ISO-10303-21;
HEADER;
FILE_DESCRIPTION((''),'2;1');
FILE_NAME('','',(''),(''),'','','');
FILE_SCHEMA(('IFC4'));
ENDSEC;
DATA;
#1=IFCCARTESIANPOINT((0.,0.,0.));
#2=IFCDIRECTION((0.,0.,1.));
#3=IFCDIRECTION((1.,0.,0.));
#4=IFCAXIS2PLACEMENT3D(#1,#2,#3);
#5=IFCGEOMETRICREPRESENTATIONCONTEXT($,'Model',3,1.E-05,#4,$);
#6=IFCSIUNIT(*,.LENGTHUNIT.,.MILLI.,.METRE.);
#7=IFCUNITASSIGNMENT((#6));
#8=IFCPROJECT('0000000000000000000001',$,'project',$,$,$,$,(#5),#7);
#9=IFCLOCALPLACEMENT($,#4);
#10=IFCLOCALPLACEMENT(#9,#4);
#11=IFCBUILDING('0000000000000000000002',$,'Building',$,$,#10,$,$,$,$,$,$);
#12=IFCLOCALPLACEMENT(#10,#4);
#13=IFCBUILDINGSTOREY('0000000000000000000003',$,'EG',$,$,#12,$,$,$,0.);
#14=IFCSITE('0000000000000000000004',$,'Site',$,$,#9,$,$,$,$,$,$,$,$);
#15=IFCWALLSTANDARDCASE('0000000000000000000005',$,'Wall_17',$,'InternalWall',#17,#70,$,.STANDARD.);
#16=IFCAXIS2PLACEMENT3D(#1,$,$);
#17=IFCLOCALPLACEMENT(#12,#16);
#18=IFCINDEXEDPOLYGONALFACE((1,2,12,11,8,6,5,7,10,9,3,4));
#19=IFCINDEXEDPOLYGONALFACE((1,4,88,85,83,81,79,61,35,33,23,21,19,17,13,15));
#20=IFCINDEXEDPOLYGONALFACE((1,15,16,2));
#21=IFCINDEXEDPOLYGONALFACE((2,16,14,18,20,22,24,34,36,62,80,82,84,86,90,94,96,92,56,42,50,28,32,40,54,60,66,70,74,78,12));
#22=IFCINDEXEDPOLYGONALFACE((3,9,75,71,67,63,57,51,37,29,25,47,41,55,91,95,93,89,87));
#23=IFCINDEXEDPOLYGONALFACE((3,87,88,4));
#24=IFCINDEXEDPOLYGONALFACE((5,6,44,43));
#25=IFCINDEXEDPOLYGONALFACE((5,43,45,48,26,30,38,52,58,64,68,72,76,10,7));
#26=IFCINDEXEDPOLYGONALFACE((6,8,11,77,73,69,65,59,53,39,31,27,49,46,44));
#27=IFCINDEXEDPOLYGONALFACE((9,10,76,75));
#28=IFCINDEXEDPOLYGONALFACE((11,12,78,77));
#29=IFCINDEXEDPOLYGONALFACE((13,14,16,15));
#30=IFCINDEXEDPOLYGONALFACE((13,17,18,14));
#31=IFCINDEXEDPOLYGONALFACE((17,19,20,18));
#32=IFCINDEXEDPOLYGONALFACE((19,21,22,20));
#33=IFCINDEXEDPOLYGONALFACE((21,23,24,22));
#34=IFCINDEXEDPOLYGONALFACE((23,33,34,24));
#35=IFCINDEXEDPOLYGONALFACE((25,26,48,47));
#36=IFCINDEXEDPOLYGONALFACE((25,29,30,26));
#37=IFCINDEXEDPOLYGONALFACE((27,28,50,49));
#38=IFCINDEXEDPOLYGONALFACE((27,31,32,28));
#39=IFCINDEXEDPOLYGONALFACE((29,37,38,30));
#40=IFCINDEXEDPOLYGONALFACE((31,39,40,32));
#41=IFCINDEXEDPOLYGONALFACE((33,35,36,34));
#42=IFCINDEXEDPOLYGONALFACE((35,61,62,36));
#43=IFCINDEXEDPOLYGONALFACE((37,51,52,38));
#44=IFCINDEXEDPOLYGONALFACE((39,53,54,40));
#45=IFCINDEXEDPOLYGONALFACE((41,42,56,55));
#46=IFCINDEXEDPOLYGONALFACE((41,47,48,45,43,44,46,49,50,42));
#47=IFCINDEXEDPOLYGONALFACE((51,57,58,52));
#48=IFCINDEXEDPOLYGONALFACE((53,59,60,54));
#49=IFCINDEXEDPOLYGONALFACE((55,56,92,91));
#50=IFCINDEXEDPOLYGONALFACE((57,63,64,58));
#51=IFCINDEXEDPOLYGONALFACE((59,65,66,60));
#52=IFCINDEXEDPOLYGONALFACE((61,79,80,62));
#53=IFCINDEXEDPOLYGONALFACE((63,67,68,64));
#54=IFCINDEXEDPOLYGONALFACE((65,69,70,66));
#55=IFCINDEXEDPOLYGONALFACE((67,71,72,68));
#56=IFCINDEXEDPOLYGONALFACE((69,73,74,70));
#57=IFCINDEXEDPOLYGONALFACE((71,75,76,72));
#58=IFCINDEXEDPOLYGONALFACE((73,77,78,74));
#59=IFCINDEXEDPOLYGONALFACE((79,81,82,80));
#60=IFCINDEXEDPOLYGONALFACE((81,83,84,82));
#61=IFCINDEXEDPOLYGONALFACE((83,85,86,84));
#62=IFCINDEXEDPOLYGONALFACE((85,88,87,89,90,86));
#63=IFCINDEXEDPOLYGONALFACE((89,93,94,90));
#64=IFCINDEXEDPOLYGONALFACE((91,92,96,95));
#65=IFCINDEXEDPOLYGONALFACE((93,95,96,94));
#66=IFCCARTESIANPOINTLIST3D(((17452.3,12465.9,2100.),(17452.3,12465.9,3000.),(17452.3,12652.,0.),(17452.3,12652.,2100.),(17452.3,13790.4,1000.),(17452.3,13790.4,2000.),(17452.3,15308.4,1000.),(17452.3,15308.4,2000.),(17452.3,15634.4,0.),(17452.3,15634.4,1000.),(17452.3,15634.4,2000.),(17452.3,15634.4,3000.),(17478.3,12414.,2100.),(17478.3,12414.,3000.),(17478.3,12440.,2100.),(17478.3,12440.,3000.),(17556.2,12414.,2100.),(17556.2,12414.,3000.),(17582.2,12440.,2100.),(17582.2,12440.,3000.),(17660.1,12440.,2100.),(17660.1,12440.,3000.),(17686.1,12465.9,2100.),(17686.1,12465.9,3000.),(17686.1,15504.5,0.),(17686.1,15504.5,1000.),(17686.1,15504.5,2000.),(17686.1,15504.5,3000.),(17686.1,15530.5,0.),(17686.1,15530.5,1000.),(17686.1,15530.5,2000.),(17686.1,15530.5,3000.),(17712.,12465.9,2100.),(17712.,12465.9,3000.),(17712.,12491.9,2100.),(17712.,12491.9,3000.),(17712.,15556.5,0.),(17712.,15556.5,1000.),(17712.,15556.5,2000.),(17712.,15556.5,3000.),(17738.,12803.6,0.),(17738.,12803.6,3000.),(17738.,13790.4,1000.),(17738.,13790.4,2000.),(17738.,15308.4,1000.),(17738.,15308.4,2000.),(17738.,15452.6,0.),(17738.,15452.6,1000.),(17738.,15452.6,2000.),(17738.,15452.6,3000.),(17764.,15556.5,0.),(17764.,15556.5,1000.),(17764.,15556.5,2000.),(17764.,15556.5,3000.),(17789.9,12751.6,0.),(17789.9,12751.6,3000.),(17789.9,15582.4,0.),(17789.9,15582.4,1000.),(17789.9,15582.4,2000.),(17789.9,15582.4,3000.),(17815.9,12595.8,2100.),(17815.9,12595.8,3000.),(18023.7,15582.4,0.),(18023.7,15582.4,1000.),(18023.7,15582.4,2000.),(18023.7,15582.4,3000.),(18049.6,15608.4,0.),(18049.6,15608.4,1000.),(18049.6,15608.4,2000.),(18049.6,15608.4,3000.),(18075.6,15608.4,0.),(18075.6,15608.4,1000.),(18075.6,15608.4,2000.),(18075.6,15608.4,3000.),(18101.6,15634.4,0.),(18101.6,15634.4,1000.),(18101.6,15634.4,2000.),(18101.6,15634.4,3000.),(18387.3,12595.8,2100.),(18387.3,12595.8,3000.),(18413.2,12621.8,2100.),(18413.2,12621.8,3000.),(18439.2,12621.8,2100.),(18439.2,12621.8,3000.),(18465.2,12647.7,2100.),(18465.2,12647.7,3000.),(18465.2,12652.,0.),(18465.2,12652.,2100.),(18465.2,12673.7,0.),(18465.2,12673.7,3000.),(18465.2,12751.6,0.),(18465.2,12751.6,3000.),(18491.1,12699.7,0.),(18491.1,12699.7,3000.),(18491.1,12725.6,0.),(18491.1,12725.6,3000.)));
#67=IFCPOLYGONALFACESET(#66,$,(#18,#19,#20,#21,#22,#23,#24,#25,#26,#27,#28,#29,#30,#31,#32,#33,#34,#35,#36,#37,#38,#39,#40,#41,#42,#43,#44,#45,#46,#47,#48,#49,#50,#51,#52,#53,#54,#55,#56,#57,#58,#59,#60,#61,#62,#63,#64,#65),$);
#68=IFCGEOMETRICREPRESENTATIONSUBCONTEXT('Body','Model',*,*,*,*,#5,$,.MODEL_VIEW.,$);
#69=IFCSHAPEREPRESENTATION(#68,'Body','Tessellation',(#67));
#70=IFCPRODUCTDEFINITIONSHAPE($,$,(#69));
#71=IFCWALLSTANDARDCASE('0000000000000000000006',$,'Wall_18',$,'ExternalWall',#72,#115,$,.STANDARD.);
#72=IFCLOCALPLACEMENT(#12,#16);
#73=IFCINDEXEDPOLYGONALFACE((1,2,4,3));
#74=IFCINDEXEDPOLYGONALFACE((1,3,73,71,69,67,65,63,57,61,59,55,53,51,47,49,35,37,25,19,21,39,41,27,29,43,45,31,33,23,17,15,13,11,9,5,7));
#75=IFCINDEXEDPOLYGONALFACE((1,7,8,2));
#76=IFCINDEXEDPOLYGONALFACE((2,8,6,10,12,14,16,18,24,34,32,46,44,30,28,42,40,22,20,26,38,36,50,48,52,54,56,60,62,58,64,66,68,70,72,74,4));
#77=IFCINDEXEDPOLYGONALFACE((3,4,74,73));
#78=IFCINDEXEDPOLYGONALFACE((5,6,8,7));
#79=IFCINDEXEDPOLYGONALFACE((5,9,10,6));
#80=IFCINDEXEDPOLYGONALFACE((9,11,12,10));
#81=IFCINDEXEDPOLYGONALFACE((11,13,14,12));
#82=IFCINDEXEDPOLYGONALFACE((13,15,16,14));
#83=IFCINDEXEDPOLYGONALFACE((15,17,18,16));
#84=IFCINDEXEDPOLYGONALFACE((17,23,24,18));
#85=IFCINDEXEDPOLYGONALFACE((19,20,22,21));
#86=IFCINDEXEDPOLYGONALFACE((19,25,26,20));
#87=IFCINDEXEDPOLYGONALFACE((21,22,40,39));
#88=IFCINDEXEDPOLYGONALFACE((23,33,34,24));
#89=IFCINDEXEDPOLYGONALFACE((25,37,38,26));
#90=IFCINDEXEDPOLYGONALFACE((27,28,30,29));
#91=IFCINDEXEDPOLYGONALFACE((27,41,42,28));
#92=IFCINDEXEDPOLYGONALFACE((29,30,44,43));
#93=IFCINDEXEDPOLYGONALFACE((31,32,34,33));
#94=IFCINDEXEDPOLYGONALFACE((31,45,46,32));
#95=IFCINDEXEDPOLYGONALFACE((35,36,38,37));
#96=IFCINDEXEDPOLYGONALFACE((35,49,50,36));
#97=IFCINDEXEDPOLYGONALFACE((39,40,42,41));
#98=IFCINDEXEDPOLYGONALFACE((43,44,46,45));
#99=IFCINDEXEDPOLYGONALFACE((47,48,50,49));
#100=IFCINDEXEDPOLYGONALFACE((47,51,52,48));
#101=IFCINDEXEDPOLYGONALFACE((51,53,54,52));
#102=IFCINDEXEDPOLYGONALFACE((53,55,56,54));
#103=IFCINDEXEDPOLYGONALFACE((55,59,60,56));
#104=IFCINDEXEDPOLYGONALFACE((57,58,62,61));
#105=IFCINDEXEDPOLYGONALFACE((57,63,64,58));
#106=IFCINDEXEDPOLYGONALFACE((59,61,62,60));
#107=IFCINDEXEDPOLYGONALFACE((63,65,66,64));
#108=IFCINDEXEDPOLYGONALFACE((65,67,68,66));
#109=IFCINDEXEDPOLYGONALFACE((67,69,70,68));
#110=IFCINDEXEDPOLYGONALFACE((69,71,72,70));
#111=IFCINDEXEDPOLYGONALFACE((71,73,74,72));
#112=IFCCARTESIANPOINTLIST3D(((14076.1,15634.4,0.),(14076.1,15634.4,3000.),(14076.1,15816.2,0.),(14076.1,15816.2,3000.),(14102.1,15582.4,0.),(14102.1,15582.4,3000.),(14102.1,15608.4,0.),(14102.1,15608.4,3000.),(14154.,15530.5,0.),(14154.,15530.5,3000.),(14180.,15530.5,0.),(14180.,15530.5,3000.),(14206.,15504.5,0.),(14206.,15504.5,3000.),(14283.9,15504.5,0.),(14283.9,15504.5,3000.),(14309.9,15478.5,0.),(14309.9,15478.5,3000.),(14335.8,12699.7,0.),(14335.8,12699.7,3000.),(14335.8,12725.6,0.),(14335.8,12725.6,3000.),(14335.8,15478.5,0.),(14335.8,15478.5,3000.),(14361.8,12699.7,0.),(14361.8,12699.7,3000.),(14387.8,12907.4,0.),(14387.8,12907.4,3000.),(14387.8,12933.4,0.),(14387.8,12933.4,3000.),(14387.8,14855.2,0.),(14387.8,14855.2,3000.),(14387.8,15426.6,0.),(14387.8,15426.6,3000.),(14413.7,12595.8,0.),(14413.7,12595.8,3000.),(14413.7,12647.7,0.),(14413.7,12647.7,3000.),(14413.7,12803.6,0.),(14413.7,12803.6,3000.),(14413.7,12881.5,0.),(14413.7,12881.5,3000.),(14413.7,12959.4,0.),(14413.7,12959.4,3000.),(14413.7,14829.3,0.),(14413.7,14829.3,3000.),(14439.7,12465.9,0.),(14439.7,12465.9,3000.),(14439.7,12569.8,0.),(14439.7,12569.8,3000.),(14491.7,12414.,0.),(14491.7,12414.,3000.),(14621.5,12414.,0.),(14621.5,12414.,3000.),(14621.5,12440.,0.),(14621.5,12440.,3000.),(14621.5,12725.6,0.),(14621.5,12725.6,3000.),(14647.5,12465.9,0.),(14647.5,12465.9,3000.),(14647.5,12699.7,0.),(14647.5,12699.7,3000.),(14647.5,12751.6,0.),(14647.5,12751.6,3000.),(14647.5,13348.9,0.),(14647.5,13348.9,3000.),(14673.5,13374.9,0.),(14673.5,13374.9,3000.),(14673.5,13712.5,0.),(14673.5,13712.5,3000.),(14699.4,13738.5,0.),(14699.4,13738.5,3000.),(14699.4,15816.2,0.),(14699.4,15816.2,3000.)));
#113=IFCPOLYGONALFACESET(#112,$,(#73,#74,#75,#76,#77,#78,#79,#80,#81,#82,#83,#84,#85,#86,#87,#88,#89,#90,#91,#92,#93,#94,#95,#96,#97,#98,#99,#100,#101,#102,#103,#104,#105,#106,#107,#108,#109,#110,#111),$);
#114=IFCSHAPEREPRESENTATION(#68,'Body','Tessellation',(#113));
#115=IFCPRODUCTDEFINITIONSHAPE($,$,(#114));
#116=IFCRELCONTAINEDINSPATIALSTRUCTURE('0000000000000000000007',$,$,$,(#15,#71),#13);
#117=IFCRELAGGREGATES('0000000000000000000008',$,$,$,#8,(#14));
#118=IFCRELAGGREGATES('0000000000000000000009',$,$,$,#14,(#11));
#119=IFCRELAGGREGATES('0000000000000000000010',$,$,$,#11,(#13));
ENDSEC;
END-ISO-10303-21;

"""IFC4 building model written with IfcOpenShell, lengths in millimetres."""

from ifc_helpers import new_model, si_unit, frame, origin_with_axes, place, context, subcontext, project, spatial, polyline, rectangle, outline, extrude, element, save


model = new_model("IFC4")

# Units and contexts
model_context = context("Model", 3, precision=1e-05, world=origin_with_axes())
body_context = subcontext(model_context, "Body", "Model", "MODEL_VIEW")
ifc_project = project(units=[si_unit("LENGTHUNIT", "METRE", prefix="MILLI")], contexts=[model_context])

# Site, building, storey
site_placement = place(None, origin_with_axes())
site = spatial("IfcSite", under=ifc_project, at=site_placement, Name="Site")
building_placement = place(site_placement, origin_with_axes())
building = spatial("IfcBuilding", under=site, at=building_placement, Name="Building")
storey_placement = place(building_placement, origin_with_axes())
storey = spatial("IfcBuildingStorey", under=building, at=storey_placement, Name="EG", Elevation=0.0)

# Wall, openings
wall_1_placement = place(storey_placement, origin_with_axes())
wall_1 = element("IfcWallStandardCase", 1, at=wall_1_placement, inside=storey, Name="Wall_17", ObjectType="InternalWall", PredefinedType="STANDARD", context=body_context, shape_type="SweptSolid", body=[
    extrude(outline(polyline([(17478.3, 12414.0, 0.0), (17478.3, 12440.0, 0.0), (17452.3, 12465.9, 0.0), (17452.3, 15634.4, 0.0), (18101.6, 15634.4, 0.0), (18075.6, 15608.4, 0.0), (18049.6, 15608.4, 0.0), (18023.7, 15582.4, 0.0), (17789.9, 15582.4, 0.0), (17764.0, 15556.5, 0.0), (17712.0, 15556.5, 0.0), (17686.1, 15530.5, 0.0), (17686.1, 15504.5, 0.0), (17738.0, 15452.6, 0.0), (17738.0, 12803.6, 0.0), (17789.9, 12751.6, 0.0), (18465.2, 12751.6, 0.0), (18491.1, 12725.6, 0.0), (18491.1, 12699.7, 0.0), (18465.2, 12673.7, 0.0), (18465.2, 12647.7, 0.0), (18439.2, 12621.8, 0.0), (18413.2, 12621.8, 0.0), (18387.3, 12595.8, 0.0), (17815.9, 12595.8, 0.0), (17712.0, 12491.9, 0.0), (17712.0, 12465.9, 0.0), (17686.1, 12465.9, 0.0), (17660.1, 12440.0, 0.0), (17582.2, 12440.0, 0.0), (17556.2, 12414.0, 0.0), (17478.3, 12414.0, 0.0)])), origin_with_axes(), (0.0, 0.0, 1.0), 3000.0),
])
opening_1_placement = place(wall_1_placement, origin_with_axes())
element("IfcOpeningElement", 2, at=opening_1_placement, inside=storey, cuts=wall_1, context=body_context, shape_type="SweptSolid", body=[
    extrude(rectangle(XDim=450.0, YDim=1038.8), frame((17971.7, 12427.0, 0.0), z_axis=(0.0, 0.0, 1.0), x_axis=(0.0, 1.0, 0.0)), (0.0, 0.0, 1.0), 2100.0),
])
opening_2_placement = place(wall_1_placement, origin_with_axes())
element("IfcOpeningElement", 3, at=opening_2_placement, inside=storey, cuts=wall_1, context=body_context, shape_type="SweptSolid", body=[
    extrude(rectangle(XDim=600.0, YDim=1038.8), frame((17971.7, 15608.4, 1000.0), z_axis=(0.0, 0.0, 1.0), x_axis=(0.0, 1.0, 0.0)), (0.0, 0.0, 1.0), 1000.0),
])
opening_3_placement = place(wall_1_placement, origin_with_axes())
element("IfcOpeningElement", 4, at=opening_3_placement, inside=storey, cuts=wall_1, context=body_context, shape_type="SweptSolid", body=[
    extrude(rectangle(XDim=1843.9, YDim=1038.8), frame((17971.7, 14712.4, 1000.0), z_axis=(0.0, 0.0, 1.0), x_axis=(0.0, 1.0, 0.0)), (0.0, 0.0, 1.0), 1000.0),
])

# Wall, opening
wall_2_placement = place(storey_placement, origin_with_axes())
wall_2 = element("IfcWallStandardCase", 5, at=wall_2_placement, inside=storey, Name="Wall_18", ObjectType="ExternalWall", PredefinedType="STANDARD", context=body_context, shape_type="SweptSolid", body=[
    extrude(outline(polyline([(14491.7, 12414.0, 0.0), (14439.7, 12465.9, 0.0), (14439.7, 12569.8, 0.0), (14413.7, 12595.8, 0.0), (14413.7, 12647.7, 0.0), (14361.8, 12699.7, 0.0), (14335.8, 12699.7, 0.0), (14335.8, 12725.6, 0.0), (14413.7, 12803.6, 0.0), (14413.7, 12881.5, 0.0), (14387.8, 12907.4, 0.0), (14387.8, 12933.4, 0.0), (14413.7, 12959.4, 0.0), (14413.7, 14829.3, 0.0), (14387.8, 14855.2, 0.0), (14387.8, 15426.6, 0.0), (14335.8, 15478.5, 0.0), (14309.9, 15478.5, 0.0), (14283.9, 15504.5, 0.0), (14206.0, 15504.5, 0.0), (14180.0, 15530.5, 0.0), (14154.0, 15530.5, 0.0), (14102.1, 15582.4, 0.0), (14102.1, 15608.4, 0.0), (14076.1, 15634.4, 0.0), (14076.1, 15816.2, 0.0), (14699.4, 15816.2, 0.0), (14699.4, 13738.5, 0.0), (14673.5, 13712.5, 0.0), (14673.5, 13374.9, 0.0), (14647.5, 13348.9, 0.0), (14647.5, 12751.6, 0.0), (14621.5, 12725.6, 0.0), (14647.5, 12699.7, 0.0), (14647.5, 12465.9, 0.0), (14621.5, 12440.0, 0.0), (14621.5, 12414.0, 0.0), (14491.7, 12414.0, 0.0)])), origin_with_axes(), (0.0, 0.0, 1.0), 3000.0),
])
opening_4_placement = place(wall_2_placement, origin_with_axes())
element("IfcOpeningElement", 6, at=opening_4_placement, inside=storey, cuts=wall_2, context=body_context, shape_type="SweptSolid", body=[
    extrude(rectangle(XDim=900.0, YDim=623.3), frame((14262.5, 11949.6, 0.0), z_axis=(0.0, 0.0, 1.0), x_axis=(0.0, -1.0, 0.0)), (0.0, 0.0, 1.0), 2100.0),
])

save(model, "model.ifc")
